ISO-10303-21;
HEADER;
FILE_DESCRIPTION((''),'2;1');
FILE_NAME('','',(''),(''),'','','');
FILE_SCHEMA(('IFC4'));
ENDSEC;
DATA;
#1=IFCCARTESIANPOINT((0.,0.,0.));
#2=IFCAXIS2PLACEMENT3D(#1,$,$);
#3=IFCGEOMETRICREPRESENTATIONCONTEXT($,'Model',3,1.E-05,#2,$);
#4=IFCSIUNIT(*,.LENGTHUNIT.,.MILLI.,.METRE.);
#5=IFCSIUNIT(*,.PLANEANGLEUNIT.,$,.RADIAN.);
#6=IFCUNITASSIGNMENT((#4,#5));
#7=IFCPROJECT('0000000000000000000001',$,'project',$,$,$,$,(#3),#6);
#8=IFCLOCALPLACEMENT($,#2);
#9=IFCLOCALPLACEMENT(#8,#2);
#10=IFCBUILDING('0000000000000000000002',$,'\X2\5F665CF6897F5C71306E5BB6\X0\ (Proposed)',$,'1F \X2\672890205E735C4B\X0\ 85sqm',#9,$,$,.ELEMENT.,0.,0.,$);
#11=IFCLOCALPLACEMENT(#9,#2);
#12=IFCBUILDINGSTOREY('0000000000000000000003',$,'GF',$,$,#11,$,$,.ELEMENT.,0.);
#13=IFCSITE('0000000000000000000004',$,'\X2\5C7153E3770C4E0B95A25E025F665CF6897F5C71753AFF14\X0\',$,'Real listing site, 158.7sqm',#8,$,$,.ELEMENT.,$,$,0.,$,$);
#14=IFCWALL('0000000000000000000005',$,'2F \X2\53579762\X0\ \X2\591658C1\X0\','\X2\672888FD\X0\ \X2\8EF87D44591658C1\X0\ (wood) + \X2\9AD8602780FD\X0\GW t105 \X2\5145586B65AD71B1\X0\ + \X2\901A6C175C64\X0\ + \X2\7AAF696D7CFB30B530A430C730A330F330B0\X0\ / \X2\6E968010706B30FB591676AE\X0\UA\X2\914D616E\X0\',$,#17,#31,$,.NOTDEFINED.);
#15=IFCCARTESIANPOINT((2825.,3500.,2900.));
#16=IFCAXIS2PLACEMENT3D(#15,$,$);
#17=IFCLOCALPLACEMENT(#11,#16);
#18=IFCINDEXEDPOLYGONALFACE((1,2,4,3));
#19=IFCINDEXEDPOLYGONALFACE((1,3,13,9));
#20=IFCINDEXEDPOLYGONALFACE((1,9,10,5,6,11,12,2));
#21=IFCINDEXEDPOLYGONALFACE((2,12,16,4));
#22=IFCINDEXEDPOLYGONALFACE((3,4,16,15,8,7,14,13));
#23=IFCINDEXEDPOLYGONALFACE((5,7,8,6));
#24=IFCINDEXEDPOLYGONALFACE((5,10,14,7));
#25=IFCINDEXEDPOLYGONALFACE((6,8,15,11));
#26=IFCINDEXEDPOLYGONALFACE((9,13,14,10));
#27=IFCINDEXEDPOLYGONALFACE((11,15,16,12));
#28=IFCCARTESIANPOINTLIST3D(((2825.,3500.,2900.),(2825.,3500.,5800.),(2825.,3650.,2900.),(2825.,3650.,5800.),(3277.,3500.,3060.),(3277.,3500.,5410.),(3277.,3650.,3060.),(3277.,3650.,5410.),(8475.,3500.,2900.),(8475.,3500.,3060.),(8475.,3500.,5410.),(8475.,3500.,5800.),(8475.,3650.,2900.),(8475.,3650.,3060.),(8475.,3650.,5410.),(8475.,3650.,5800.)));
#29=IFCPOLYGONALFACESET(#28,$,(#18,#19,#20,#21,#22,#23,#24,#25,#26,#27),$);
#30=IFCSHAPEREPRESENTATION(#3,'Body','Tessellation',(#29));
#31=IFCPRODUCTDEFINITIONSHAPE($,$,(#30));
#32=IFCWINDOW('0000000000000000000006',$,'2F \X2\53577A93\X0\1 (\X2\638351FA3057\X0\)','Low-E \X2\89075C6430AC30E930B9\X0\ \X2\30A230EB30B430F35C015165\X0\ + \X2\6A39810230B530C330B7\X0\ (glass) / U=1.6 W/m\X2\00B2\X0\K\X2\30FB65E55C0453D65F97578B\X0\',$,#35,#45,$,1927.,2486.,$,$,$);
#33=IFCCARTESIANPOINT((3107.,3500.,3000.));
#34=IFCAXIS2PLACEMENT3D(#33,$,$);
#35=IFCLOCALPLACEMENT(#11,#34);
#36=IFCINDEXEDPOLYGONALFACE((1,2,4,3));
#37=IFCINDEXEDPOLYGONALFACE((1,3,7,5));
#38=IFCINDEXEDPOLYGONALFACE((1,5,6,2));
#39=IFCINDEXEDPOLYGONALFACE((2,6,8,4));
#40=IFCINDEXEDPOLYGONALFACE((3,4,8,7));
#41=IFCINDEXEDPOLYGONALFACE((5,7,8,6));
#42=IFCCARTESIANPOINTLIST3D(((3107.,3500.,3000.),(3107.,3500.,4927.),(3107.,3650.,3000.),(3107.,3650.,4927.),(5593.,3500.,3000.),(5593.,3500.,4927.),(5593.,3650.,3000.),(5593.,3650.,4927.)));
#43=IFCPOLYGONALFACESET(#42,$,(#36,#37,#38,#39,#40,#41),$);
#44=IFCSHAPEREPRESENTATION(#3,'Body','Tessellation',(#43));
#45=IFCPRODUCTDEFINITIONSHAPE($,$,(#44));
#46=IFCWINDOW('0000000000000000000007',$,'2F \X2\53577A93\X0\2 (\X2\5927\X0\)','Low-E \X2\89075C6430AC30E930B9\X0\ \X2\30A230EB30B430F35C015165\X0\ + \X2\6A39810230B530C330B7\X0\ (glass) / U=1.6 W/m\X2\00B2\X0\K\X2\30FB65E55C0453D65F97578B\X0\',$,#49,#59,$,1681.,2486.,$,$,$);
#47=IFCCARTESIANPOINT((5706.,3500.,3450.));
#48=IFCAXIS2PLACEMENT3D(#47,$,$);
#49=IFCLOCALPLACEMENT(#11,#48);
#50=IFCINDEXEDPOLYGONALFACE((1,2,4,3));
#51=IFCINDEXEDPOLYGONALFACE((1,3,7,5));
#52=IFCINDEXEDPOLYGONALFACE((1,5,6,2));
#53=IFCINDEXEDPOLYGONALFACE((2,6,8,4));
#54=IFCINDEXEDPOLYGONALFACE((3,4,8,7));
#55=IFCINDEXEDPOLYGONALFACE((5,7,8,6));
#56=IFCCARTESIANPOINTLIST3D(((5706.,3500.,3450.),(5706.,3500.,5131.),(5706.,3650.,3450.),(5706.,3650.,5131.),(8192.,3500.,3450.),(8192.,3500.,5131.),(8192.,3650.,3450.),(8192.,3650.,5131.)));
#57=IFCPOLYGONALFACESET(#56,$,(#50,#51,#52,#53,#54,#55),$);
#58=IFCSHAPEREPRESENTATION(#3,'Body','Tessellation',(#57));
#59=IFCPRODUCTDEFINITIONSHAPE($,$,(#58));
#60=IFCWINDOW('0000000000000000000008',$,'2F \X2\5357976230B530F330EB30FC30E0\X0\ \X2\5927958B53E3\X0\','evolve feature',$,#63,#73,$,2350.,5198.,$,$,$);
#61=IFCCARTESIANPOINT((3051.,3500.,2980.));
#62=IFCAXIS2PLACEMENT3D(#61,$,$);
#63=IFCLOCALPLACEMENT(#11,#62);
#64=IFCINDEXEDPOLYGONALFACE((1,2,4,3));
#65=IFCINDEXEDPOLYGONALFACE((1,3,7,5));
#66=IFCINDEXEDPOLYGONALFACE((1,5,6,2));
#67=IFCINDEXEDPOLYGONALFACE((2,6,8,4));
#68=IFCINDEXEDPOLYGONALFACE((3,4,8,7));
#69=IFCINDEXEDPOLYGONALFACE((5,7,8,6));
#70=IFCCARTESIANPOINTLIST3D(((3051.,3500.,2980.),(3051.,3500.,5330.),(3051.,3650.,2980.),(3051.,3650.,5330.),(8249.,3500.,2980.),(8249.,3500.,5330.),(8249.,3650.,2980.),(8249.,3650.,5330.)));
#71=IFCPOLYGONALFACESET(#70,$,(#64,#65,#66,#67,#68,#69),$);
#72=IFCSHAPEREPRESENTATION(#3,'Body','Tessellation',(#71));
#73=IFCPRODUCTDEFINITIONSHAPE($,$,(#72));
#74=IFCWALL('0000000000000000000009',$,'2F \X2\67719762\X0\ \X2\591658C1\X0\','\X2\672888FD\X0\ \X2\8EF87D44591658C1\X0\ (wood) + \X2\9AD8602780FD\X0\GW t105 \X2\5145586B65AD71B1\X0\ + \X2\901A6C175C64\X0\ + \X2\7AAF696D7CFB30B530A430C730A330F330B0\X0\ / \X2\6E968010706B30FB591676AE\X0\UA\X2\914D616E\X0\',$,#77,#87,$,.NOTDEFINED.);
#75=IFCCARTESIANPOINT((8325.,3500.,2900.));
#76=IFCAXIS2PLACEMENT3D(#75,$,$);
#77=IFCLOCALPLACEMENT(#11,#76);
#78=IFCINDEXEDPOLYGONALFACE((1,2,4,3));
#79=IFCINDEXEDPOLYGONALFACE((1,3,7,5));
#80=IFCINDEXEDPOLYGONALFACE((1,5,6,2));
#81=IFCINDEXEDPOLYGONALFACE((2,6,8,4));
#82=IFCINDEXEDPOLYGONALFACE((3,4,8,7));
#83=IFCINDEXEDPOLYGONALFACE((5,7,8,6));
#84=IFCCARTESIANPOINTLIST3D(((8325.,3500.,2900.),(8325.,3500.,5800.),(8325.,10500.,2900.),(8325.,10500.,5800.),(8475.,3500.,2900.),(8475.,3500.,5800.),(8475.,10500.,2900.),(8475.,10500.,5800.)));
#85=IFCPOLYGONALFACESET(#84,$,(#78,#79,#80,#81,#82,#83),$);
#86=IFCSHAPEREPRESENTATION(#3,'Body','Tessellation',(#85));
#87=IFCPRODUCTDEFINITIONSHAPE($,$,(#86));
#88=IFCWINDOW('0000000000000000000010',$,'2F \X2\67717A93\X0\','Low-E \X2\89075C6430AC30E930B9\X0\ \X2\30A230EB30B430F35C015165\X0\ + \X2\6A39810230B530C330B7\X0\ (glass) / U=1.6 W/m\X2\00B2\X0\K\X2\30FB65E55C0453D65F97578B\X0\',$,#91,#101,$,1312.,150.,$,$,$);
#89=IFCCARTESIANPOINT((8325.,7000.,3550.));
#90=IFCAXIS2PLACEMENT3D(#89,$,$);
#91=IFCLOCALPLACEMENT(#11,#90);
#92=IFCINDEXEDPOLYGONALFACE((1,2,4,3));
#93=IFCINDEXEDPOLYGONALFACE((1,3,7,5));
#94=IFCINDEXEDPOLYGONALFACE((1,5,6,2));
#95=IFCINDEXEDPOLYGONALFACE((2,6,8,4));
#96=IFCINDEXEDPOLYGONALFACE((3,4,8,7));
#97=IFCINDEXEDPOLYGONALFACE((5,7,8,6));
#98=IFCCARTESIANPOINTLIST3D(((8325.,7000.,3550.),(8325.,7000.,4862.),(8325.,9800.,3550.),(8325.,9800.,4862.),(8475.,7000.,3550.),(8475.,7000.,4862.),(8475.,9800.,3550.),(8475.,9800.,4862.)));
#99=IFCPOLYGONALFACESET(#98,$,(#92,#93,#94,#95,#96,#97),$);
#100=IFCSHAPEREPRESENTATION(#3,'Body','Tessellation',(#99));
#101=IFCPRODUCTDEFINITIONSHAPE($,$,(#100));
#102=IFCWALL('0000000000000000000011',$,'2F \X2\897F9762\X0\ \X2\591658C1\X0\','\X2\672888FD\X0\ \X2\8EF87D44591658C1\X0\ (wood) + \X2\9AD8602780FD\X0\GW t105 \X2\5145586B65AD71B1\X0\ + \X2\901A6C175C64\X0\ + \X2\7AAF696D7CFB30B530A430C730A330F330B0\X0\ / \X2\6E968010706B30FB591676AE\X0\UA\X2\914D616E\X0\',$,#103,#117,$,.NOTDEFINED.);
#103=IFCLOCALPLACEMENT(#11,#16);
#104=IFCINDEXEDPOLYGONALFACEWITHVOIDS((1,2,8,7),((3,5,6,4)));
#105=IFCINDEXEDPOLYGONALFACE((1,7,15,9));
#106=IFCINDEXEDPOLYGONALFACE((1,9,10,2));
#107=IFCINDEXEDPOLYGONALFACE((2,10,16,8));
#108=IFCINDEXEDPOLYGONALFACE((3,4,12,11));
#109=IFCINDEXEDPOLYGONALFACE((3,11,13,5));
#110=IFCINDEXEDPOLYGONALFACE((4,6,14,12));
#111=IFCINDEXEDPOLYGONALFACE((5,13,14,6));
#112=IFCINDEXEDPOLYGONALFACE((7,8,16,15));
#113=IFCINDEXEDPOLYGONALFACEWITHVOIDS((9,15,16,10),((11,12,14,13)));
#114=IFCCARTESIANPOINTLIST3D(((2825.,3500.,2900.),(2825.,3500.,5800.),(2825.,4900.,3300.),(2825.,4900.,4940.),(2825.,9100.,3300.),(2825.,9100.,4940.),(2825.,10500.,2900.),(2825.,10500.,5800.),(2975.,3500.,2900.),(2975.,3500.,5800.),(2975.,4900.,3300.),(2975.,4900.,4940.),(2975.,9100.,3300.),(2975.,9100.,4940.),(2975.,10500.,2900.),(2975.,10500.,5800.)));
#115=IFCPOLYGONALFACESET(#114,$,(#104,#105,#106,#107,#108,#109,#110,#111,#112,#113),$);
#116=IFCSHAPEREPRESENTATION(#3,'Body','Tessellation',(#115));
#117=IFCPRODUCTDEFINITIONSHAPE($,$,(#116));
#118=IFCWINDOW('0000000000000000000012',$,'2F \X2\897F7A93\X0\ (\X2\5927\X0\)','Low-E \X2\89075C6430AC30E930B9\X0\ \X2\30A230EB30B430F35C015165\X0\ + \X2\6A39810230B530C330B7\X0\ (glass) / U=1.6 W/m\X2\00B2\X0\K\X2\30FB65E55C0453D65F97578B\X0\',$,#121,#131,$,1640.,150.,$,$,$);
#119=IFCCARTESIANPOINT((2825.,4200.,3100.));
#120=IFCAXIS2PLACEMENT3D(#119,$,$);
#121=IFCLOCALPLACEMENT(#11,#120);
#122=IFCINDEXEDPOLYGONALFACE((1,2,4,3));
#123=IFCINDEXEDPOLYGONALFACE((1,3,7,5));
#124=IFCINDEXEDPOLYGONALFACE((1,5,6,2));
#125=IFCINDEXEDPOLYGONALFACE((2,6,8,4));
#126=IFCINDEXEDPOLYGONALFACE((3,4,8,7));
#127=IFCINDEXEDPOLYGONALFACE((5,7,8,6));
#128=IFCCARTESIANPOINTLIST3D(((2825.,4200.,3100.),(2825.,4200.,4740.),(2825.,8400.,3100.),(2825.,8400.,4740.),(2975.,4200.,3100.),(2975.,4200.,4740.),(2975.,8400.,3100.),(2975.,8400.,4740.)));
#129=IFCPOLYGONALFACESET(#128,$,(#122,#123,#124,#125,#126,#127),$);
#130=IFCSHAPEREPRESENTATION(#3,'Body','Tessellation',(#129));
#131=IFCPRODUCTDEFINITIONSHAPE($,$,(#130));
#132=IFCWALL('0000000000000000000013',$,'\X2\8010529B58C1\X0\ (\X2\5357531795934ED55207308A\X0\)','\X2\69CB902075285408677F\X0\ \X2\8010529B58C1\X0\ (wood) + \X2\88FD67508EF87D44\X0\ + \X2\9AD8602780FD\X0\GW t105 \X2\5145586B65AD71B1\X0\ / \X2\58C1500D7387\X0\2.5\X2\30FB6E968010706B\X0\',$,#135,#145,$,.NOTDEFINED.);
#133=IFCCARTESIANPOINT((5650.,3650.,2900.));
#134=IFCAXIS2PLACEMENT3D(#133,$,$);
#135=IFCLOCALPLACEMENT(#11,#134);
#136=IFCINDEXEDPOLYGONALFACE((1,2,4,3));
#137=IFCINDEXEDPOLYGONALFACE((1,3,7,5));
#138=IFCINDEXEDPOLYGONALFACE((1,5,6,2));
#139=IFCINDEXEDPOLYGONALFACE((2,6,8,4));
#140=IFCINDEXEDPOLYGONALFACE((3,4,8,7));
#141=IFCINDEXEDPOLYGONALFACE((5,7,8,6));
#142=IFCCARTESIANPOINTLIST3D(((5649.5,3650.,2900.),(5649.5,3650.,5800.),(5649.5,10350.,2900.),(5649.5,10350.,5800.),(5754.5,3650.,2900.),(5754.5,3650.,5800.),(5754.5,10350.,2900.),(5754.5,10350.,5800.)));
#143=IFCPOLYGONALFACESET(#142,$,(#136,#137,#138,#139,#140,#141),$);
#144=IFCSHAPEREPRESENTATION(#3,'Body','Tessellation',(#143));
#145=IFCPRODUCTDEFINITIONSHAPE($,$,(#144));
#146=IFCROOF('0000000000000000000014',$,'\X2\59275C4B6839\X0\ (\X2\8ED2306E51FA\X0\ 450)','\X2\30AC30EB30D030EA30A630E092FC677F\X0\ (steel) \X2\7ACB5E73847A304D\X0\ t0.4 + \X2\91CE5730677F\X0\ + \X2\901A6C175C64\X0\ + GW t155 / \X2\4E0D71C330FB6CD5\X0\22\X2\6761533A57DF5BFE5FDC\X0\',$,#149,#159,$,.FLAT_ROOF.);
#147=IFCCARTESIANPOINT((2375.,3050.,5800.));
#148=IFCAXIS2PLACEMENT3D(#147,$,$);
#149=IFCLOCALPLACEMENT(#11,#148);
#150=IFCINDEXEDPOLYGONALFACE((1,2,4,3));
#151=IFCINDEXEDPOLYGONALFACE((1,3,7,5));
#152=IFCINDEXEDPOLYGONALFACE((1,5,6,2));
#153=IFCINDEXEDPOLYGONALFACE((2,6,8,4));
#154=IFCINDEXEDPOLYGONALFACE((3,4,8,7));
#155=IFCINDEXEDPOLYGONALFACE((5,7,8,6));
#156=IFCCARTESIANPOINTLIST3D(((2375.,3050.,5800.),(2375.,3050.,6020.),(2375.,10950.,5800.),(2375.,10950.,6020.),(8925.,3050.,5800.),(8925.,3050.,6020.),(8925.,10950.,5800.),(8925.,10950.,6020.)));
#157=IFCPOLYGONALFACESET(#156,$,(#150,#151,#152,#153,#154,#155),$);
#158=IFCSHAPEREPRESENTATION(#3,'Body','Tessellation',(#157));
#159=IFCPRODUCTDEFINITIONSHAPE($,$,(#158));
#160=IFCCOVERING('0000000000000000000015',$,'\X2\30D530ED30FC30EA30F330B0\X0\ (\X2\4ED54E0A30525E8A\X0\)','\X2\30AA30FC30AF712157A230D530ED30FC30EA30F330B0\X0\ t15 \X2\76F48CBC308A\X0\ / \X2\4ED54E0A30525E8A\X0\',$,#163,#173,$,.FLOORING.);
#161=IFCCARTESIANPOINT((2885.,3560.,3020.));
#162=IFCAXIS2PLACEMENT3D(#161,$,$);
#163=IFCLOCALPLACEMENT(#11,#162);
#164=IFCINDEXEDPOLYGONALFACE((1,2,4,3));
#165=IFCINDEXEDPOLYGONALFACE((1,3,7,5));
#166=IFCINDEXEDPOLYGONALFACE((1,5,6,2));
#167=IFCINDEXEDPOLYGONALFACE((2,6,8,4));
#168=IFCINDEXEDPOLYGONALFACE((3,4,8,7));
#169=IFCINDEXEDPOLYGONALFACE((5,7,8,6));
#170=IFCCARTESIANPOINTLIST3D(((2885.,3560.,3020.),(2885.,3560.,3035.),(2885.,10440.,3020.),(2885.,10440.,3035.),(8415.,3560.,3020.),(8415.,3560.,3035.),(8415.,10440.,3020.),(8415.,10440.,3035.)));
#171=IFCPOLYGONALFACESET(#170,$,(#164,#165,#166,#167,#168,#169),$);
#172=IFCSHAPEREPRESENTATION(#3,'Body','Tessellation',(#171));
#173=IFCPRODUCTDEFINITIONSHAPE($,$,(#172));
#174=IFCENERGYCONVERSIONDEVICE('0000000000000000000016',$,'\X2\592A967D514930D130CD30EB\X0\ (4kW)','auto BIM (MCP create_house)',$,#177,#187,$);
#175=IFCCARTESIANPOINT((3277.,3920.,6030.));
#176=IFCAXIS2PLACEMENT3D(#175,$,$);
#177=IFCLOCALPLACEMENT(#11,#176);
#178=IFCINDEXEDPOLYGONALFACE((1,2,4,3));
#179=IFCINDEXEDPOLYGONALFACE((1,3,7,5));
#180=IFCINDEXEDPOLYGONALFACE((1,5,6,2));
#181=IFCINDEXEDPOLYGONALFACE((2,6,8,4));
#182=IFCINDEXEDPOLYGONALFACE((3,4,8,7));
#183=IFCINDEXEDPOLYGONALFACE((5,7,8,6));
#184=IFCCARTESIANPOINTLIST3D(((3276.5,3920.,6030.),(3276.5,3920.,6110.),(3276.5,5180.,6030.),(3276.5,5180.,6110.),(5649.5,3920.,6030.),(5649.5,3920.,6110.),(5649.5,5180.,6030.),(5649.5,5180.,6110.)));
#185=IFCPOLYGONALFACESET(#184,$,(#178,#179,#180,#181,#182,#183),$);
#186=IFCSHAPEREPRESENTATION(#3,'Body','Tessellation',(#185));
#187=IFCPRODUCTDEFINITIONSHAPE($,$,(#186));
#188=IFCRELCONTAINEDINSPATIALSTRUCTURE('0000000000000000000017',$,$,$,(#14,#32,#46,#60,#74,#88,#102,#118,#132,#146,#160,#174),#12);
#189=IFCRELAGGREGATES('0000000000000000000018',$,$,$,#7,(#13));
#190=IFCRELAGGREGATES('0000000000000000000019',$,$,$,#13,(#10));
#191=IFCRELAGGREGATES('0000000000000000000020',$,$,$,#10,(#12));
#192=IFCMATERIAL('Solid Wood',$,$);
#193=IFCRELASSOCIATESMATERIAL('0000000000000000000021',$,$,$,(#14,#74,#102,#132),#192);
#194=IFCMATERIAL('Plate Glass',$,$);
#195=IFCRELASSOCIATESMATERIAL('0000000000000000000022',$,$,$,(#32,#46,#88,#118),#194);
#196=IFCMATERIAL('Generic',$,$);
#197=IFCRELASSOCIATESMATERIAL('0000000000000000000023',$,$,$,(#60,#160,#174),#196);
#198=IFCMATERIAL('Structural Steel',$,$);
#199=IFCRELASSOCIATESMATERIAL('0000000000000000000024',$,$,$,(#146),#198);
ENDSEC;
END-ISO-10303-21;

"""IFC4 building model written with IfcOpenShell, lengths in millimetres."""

from ifc_helpers import new_model, si_unit, frame, frame_2d, origin, place, context, project, spatial, rectangle, extrude, material, element, fill, save


model = new_model("IFC4")

# Units and contexts
model_context = context("Model", 3, precision=1e-05, world=origin())
ifc_project = project(units=[si_unit("LENGTHUNIT", "METRE", prefix="MILLI"), si_unit("PLANEANGLEUNIT", "RADIAN")], contexts=[model_context])

# Site, building, storey
site_placement = place(None, origin())
site = spatial("IfcSite", under=ifc_project, at=site_placement, Name="山口県下関市彦島西山町４", ObjectType="Real listing site, 158.7sqm", CompositionType="ELEMENT", RefElevation=0.0)
building_placement = place(site_placement, origin())
building = spatial("IfcBuilding", under=site, at=building_placement, Name="彦島西山の家 (Proposed)", ObjectType="1F 木造平屋 85sqm", CompositionType="ELEMENT", ElevationOfRefHeight=0.0, ElevationOfTerrain=0.0)
storey_placement = place(building_placement, origin())
storey = spatial("IfcBuildingStorey", under=building, at=storey_placement, Name="GF", CompositionType="ELEMENT", Elevation=0.0)

# Shared definitions
ifc_material_1 = material(Name="Solid Wood")

# Wall, openings, windows
wall_1_placement = place(storey_placement, frame((2825.0, 3500.0, 2900.0)))
wall_1 = element("IfcWall", 1, at=wall_1_placement, inside=storey, material=ifc_material_1, Name="2F 南面 外壁", Description="木製 軸組外壁 (wood) + 高性能GW t105 充填断熱 + 通気層 + 窯業系サイディング / 準耐火・外皮UA配慮", PredefinedType="NOTDEFINED", context=model_context, shape_type="SweptSolid", body=[
    extrude(rectangle(XDim=5650.0, YDim=150.0, at=frame_2d((2825.0, 75.0))), frame((2825.0, 3500.0, 2900.0)), (0.0, 0.0, 1.0), 2900.0),
])
opening_1_placement = place(storey_placement, frame((3107.0, 3500.0, 3000.0)))
opening_1 = element("IfcOpeningElement", 2, at=opening_1_placement, cuts=wall_1, PredefinedType="NOTDEFINED", context=model_context, shape_type="SweptSolid", body=[
    extrude(rectangle(XDim=2486.0, YDim=150.0, at=frame_2d((1243.0, 75.0))), frame((3107.0, 3500.0, 3000.0)), (0.0, 0.0, 1.0), 1927.0),
])
opening_2_placement = place(storey_placement, frame((5706.0, 3500.0, 3450.0)))
opening_2 = element("IfcOpeningElement", 3, at=opening_2_placement, cuts=wall_1, PredefinedType="NOTDEFINED", context=model_context, shape_type="SweptSolid", body=[
    extrude(rectangle(XDim=2486.0, YDim=150.0, at=frame_2d((1243.0, 75.0))), frame((5706.0, 3500.0, 3450.0)), (0.0, 0.0, 1.0), 1681.0),
])
opening_3_placement = place(storey_placement, frame((3051.0, 3500.0, 2980.0)))
opening_3 = element("IfcOpeningElement", 4, at=opening_3_placement, cuts=wall_1, PredefinedType="NOTDEFINED", context=model_context, shape_type="SweptSolid", body=[
    extrude(rectangle(XDim=5198.0, YDim=150.0, at=frame_2d((2599.0, 75.0))), frame((3051.0, 3500.0, 2980.0)), (0.0, 0.0, 1.0), 2350.0),
])
ifc_material_2 = material(Name="Plate Glass")
window_1_placement = place(storey_placement, frame((3107.0, 3500.0, 3000.0)))
window_1 = element("IfcWindow", 5, at=window_1_placement, inside=storey, material=ifc_material_2, Name="2F 南窓1 (掃出し)", Description="Low-E 複層ガラス アルゴン封入 + 樹脂サッシ (glass) / U=1.6 W/m²K・日射取得型", OverallHeight=1927.0, OverallWidth=2486.0, context=model_context, shape_type="SweptSolid", body=[
    extrude(rectangle(XDim=2486.0, YDim=150.0, at=frame_2d((1243.0, 75.0))), frame((3107.0, 3500.0, 3000.0)), (0.0, 0.0, 1.0), 1927.0),
])
fill(opening_1, window_1)
window_2_placement = place(storey_placement, frame((5706.0, 3500.0, 3450.0)))
window_2 = element("IfcWindow", 6, at=window_2_placement, inside=storey, material=ifc_material_2, Name="2F 南窓2 (大)", Description="Low-E 複層ガラス アルゴン封入 + 樹脂サッシ (glass) / U=1.6 W/m²K・日射取得型", OverallHeight=1681.0, OverallWidth=2486.0, context=model_context, shape_type="SweptSolid", body=[
    extrude(rectangle(XDim=2486.0, YDim=150.0, at=frame_2d((1243.0, 75.0))), frame((5706.0, 3500.0, 3450.0)), (0.0, 0.0, 1.0), 1681.0),
])
fill(opening_2, window_2)
ifc_material_3 = material(Name="Generic")
window_3_placement = place(storey_placement, frame((3051.0, 3500.0, 2980.0)))
window_3 = element("IfcWindow", 7, at=window_3_placement, inside=storey, material=ifc_material_3, Name="2F 南面サンルーム 大開口", Description="evolve feature", OverallHeight=2350.0, OverallWidth=5198.0, context=model_context, shape_type="SweptSolid", body=[
    extrude(rectangle(XDim=5198.0, YDim=150.0, at=frame_2d((2599.0, 75.0))), frame((3051.0, 3500.0, 2980.0)), (0.0, 0.0, 1.0), 2350.0),
])
fill(opening_3, window_3)

# Walls, openings, windows
wall_2_placement = place(storey_placement, frame((8325.0, 3500.0, 2900.0)))
wall_2 = element("IfcWall", 8, at=wall_2_placement, inside=storey, material=ifc_material_1, Name="2F 東面 外壁", Description="木製 軸組外壁 (wood) + 高性能GW t105 充填断熱 + 通気層 + 窯業系サイディング / 準耐火・外皮UA配慮", PredefinedType="NOTDEFINED", context=model_context, shape_type="SweptSolid", body=[
    extrude(rectangle(XDim=150.0, YDim=7000.0, at=frame_2d((75.0, 3500.0))), frame((8325.0, 3500.0, 2900.0)), (0.0, 0.0, 1.0), 2900.0),
])
opening_4_placement = place(storey_placement, frame((8325.0, 7000.0, 3550.0)))
opening_4 = element("IfcOpeningElement", 9, at=opening_4_placement, cuts=wall_2, PredefinedType="NOTDEFINED", context=model_context, shape_type="SweptSolid", body=[
    extrude(rectangle(XDim=150.0, YDim=2800.0, at=frame_2d((75.0, 1400.0))), frame((8325.0, 7000.0, 3550.0)), (0.0, 0.0, 1.0), 1312.0),
])
window_4_placement = place(storey_placement, frame((8325.0, 7000.0, 3550.0)))
window_4 = element("IfcWindow", 10, at=window_4_placement, inside=storey, material=ifc_material_2, Name="2F 東窓", Description="Low-E 複層ガラス アルゴン封入 + 樹脂サッシ (glass) / U=1.6 W/m²K・日射取得型", OverallHeight=1312.0, OverallWidth=150.0, context=model_context, shape_type="SweptSolid", body=[
    extrude(rectangle(XDim=150.0, YDim=2800.0, at=frame_2d((75.0, 1400.0))), frame((8325.0, 7000.0, 3550.0)), (0.0, 0.0, 1.0), 1312.0),
])
fill(opening_4, window_4)
wall_3_placement = place(storey_placement, frame((2825.0, 3500.0, 2900.0)))
wall_3 = element("IfcWall", 11, at=wall_3_placement, inside=storey, material=ifc_material_1, Name="2F 西面 外壁", Description="木製 軸組外壁 (wood) + 高性能GW t105 充填断熱 + 通気層 + 窯業系サイディング / 準耐火・外皮UA配慮", PredefinedType="NOTDEFINED", context=model_context, shape_type="SweptSolid", body=[
    extrude(rectangle(XDim=150.0, YDim=7000.0, at=frame_2d((75.0, 3500.0))), frame((2825.0, 3500.0, 2900.0)), (0.0, 0.0, 1.0), 2900.0),
])
opening_5_placement = place(storey_placement, frame((2825.0, 4200.0, 3100.0)))
opening_5 = element("IfcOpeningElement", 12, at=opening_5_placement, cuts=wall_3, PredefinedType="NOTDEFINED", context=model_context, shape_type="SweptSolid", body=[
    extrude(rectangle(XDim=150.0, YDim=4200.0, at=frame_2d((75.0, 2100.0))), frame((2825.0, 4200.0, 3100.0)), (0.0, 0.0, 1.0), 1640.0),
])
window_5_placement = place(storey_placement, frame((2825.0, 4200.0, 3100.0)))
window_5 = element("IfcWindow", 13, at=window_5_placement, inside=storey, material=ifc_material_2, Name="2F 西窓 (大)", Description="Low-E 複層ガラス アルゴン封入 + 樹脂サッシ (glass) / U=1.6 W/m²K・日射取得型", OverallHeight=1640.0, OverallWidth=150.0, context=model_context, shape_type="SweptSolid", body=[
    extrude(rectangle(XDim=150.0, YDim=4200.0, at=frame_2d((75.0, 2100.0))), frame((2825.0, 4200.0, 3100.0)), (0.0, 0.0, 1.0), 1640.0),
])
fill(opening_5, window_5)

# Wall
wall_4_placement = place(storey_placement, frame((5650.0, 3650.0, 2900.0)))
element("IfcWall", 14, at=wall_4_placement, inside=storey, material=ifc_material_1, Name="耐力壁 (南北間仕切り)", Description="構造用合板 耐力壁 (wood) + 製材軸組 + 高性能GW t105 充填断熱 / 壁倍率2.5・準耐火", PredefinedType="NOTDEFINED", context=model_context, shape_type="SweptSolid", body=[
    extrude(rectangle(XDim=105.0, YDim=6700.0, at=frame_2d((52.0, 3350.0))), frame((5650.0, 3650.0, 2900.0)), (0.0, 0.0, 1.0), 2900.0),
])

# Roof
ifc_material_4 = material(Name="Structural Steel")
roof_placement = place(storey_placement, frame((2375.0, 3050.0, 5800.0)))
element("IfcRoof", 15, at=roof_placement, inside=storey, material=ifc_material_4, Name="大屋根 (軒の出 450)", Description="ガルバリウム鋼板 (steel) 立平葺き t0.4 + 野地板 + 通気層 + GW t155 / 不燃・法22条区域対応", PredefinedType="FLAT_ROOF", context=model_context, shape_type="SweptSolid", body=[
    extrude(rectangle(XDim=6550.0, YDim=7900.0, at=frame_2d((3275.0, 3950.0))), frame((2375.0, 3050.0, 5800.0)), (0.0, 0.0, 1.0), 220.0),
])

# Covering
covering_placement = place(storey_placement, frame((2885.0, 3560.0, 3020.0)))
element("IfcCovering", 16, at=covering_placement, inside=storey, material=ifc_material_3, Name="フローリング (仕上げ床)", Description="オーク無垢フローリング t15 直貼り / 仕上げ床", PredefinedType="FLOORING", context=model_context, shape_type="SweptSolid", body=[
    extrude(rectangle(XDim=5530.0, YDim=6880.0, at=frame_2d((2765.0, 3440.0))), frame((2885.0, 3560.0, 3020.0)), (0.0, 0.0, 1.0), 15.0),
])

# Energy conversion device
energy_conversion_device_placement = place(storey_placement, frame((3277.0, 3920.0, 6030.0)))
element("IfcEnergyConversionDevice", 17, at=energy_conversion_device_placement, inside=storey, material=ifc_material_3, Name="太陽光パネル (4kW)", Description="auto BIM (MCP create_house)", context=model_context, shape_type="SweptSolid", body=[
    extrude(rectangle(XDim=2373.0, YDim=1260.0, at=frame_2d((1186.0, 630.0))), frame((3277.0, 3920.0, 6030.0)), (0.0, 0.0, 1.0), 80.0),
])

save(model, "model.ifc")
